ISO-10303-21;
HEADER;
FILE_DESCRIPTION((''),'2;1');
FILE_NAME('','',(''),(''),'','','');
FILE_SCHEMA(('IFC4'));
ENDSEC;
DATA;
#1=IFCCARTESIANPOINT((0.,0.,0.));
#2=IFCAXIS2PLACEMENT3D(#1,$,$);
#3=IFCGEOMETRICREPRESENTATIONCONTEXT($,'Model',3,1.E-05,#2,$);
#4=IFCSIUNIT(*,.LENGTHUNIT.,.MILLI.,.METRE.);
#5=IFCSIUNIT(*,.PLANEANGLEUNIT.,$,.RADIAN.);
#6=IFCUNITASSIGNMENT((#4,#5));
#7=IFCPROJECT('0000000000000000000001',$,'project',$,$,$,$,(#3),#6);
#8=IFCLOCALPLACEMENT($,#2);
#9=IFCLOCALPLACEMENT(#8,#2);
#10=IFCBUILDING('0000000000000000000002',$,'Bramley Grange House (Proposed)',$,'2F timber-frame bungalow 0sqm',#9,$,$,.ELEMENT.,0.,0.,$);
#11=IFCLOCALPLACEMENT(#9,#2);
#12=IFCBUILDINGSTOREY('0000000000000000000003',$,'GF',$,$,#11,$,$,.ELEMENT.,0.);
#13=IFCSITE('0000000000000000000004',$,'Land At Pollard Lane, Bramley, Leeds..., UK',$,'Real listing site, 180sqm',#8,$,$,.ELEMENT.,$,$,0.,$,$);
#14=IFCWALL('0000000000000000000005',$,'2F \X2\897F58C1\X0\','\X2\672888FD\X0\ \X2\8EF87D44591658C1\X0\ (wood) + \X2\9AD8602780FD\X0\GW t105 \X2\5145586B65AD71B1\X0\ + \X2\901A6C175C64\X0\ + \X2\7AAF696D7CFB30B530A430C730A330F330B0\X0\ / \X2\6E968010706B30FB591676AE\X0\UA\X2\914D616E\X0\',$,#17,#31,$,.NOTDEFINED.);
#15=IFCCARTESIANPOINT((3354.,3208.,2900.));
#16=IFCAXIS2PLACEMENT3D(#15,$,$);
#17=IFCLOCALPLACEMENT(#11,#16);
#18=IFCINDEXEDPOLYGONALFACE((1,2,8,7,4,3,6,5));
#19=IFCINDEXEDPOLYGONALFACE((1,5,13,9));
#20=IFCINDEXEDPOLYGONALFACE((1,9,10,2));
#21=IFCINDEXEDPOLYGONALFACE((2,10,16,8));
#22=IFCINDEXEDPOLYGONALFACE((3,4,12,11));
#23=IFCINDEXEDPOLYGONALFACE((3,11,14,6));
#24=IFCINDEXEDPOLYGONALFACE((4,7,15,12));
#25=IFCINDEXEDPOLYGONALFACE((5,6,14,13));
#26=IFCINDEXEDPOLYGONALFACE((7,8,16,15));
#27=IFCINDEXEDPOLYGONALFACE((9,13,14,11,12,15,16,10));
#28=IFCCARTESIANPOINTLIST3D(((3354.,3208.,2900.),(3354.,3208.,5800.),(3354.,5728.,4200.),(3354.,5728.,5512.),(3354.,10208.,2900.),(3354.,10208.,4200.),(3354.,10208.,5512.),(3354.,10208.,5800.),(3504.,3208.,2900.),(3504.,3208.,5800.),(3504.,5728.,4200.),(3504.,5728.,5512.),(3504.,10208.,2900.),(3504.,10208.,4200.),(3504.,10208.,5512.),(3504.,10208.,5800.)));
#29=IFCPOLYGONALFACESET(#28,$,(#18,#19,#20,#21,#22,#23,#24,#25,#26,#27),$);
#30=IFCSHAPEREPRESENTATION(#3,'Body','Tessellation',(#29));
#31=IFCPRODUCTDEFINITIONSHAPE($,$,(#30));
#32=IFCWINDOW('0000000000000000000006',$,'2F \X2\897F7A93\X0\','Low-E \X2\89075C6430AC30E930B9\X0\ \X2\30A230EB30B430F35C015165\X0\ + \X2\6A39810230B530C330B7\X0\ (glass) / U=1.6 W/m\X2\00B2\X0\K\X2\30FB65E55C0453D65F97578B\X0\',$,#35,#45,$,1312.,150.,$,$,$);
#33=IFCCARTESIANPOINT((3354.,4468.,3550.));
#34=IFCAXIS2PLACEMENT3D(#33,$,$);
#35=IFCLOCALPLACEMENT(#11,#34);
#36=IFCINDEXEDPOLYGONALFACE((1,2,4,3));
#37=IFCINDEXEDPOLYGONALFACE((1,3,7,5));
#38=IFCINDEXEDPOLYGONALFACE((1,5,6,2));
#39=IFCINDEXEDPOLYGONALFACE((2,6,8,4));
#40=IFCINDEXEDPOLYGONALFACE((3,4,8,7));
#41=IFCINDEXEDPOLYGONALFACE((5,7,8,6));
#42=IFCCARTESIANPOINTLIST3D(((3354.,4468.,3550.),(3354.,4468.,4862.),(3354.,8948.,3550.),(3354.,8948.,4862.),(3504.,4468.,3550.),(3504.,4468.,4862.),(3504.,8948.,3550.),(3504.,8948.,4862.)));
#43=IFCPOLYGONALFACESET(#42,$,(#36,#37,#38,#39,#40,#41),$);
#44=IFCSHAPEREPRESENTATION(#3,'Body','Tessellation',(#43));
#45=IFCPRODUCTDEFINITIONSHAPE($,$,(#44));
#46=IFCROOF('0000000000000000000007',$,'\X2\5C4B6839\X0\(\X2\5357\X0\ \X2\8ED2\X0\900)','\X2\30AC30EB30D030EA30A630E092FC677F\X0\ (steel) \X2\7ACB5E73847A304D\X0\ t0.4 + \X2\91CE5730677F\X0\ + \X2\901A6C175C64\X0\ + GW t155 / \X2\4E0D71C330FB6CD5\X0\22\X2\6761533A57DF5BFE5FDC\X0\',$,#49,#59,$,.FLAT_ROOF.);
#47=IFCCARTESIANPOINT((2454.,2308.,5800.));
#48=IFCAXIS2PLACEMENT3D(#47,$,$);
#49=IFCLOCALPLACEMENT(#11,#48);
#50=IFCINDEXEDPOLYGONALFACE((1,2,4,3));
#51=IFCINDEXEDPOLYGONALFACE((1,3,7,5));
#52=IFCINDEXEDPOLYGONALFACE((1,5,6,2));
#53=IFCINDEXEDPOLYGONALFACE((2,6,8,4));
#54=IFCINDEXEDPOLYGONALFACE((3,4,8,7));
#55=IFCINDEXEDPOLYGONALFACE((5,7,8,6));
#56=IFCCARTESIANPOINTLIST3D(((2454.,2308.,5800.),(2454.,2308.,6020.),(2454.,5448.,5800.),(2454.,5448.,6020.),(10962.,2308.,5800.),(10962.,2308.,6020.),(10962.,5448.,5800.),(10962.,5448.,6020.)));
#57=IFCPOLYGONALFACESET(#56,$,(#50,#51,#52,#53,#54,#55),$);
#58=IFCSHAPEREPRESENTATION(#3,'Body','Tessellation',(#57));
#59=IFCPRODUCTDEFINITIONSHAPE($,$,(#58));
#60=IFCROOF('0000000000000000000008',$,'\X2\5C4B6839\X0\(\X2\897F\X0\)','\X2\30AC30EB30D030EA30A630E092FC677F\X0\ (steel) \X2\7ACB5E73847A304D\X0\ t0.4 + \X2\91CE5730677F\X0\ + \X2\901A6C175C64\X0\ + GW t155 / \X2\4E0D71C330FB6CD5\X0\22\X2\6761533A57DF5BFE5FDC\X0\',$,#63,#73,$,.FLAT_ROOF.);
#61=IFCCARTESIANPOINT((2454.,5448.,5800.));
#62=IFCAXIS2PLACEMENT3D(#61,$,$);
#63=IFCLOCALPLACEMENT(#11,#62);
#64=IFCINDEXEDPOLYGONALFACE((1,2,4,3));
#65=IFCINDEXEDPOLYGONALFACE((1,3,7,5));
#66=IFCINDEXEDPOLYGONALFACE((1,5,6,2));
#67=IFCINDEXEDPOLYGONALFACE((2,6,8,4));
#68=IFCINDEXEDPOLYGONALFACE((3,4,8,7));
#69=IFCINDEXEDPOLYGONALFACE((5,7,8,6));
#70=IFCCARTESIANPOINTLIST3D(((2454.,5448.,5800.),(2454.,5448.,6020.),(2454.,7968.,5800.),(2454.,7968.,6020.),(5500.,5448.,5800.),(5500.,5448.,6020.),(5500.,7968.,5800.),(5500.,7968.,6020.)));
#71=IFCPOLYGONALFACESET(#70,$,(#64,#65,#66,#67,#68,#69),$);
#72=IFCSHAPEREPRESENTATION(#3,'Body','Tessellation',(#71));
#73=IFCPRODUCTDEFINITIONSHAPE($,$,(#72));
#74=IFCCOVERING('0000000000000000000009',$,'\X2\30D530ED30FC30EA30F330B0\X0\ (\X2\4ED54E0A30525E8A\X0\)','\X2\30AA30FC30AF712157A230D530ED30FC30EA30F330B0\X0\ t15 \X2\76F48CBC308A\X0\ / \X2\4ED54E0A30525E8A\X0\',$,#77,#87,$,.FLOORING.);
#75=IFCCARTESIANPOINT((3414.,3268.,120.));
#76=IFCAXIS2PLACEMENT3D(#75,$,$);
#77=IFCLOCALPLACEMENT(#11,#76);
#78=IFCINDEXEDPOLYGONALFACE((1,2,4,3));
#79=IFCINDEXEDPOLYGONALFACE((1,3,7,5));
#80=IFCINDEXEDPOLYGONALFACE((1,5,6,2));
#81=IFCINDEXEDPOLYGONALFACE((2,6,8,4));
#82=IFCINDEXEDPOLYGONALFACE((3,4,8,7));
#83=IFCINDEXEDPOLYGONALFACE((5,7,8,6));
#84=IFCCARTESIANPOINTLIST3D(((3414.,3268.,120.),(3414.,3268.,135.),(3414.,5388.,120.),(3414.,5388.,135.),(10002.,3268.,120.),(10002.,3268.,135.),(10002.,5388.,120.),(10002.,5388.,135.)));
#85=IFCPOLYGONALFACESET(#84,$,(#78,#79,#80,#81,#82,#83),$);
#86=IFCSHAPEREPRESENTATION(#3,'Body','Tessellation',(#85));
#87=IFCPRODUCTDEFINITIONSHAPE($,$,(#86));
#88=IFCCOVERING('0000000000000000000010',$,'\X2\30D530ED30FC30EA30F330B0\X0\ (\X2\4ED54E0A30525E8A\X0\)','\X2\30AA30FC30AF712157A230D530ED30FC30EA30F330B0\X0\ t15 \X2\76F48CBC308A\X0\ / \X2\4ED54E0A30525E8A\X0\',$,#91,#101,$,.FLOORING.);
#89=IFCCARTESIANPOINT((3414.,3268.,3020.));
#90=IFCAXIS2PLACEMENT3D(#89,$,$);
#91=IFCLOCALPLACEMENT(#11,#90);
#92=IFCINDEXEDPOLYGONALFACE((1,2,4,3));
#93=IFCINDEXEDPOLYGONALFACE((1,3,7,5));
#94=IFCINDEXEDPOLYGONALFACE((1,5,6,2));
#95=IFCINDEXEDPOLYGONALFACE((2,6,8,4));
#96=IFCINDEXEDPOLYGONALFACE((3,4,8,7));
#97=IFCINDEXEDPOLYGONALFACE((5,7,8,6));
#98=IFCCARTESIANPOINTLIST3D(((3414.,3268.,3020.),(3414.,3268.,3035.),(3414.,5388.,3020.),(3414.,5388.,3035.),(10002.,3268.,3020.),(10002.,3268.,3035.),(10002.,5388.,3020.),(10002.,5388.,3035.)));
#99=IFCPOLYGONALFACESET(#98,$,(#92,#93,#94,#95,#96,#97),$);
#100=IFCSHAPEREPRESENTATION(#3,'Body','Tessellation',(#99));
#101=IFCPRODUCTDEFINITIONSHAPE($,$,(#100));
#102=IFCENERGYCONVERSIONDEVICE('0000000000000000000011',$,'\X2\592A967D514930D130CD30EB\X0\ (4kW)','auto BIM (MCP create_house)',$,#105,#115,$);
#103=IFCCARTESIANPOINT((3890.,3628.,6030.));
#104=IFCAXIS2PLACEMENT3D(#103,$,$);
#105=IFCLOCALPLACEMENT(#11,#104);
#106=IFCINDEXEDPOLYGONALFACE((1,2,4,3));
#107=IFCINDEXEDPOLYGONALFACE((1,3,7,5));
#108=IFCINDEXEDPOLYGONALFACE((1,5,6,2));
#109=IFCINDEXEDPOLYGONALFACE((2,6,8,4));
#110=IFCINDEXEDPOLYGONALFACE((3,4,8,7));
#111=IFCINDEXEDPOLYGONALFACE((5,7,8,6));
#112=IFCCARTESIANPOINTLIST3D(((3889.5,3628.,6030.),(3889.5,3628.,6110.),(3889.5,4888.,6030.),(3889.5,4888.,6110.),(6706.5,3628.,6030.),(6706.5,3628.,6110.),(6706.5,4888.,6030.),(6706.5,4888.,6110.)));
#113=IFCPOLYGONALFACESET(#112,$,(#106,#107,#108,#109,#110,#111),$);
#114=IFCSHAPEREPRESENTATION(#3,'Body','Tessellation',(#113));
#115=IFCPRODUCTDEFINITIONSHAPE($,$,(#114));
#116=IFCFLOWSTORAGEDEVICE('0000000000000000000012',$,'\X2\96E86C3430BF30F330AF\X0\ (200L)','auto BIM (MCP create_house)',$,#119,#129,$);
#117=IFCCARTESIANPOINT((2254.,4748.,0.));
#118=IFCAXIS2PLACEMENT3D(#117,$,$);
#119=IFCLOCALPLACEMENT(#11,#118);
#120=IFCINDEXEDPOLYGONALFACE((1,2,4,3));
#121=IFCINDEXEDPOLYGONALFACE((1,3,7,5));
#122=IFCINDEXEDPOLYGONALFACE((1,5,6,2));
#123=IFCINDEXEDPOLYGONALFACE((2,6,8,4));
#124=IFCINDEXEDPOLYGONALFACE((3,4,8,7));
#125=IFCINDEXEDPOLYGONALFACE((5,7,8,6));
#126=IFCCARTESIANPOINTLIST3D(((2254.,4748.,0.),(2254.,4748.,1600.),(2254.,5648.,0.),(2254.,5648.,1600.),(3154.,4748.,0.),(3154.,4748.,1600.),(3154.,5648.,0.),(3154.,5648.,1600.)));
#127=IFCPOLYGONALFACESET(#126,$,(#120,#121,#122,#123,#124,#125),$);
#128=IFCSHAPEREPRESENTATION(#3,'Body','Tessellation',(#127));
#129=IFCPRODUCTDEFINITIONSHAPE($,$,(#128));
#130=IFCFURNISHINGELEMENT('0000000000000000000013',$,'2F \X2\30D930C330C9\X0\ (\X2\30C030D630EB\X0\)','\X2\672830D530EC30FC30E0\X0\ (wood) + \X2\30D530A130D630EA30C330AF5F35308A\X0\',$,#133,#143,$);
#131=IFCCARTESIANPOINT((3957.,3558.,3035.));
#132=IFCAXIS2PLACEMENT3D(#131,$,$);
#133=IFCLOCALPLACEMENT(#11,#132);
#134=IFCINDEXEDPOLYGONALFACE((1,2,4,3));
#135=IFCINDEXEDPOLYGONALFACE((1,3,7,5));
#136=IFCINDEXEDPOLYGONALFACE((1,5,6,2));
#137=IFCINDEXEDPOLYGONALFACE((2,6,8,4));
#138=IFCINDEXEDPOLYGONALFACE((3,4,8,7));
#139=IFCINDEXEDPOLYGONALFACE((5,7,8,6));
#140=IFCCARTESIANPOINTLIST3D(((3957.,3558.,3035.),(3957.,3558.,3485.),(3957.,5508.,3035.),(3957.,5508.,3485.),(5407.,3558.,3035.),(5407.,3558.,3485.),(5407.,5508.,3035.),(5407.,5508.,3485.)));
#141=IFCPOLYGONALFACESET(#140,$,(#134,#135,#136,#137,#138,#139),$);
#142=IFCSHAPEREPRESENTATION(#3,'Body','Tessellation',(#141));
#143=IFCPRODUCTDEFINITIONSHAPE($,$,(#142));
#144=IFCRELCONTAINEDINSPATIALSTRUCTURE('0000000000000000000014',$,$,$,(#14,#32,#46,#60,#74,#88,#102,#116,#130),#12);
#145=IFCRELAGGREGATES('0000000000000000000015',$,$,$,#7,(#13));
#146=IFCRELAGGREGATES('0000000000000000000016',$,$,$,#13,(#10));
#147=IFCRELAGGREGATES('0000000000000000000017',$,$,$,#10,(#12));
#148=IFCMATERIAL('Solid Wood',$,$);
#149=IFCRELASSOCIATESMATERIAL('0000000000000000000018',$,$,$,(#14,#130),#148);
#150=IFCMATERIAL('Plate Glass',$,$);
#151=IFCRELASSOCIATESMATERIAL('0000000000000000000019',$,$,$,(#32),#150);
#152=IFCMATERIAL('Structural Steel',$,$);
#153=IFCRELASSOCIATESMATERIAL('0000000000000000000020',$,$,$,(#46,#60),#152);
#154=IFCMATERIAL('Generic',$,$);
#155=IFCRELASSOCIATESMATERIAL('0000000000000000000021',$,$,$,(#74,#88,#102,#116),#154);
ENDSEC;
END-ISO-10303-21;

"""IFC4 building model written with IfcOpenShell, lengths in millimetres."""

from ifc_helpers import new_model, si_unit, frame, frame_2d, origin, place, context, project, spatial, rectangle, extrude, material, element, fill, save


model = new_model("IFC4")

# Units and contexts
model_context = context("Model", 3, precision=1e-05, world=origin())
ifc_project = project(units=[si_unit("LENGTHUNIT", "METRE", prefix="MILLI"), si_unit("PLANEANGLEUNIT", "RADIAN")], contexts=[model_context])

# Site, building, storey
site_placement = place(None, origin())
site = spatial("IfcSite", under=ifc_project, at=site_placement, Name="Land At Pollard Lane, Bramley, Leeds..., UK", ObjectType="Real listing site, 180sqm", CompositionType="ELEMENT", RefElevation=0.0)
building_placement = place(site_placement, origin())
building = spatial("IfcBuilding", under=site, at=building_placement, Name="Bramley Grange House (Proposed)", ObjectType="2F timber-frame bungalow 0sqm", CompositionType="ELEMENT", ElevationOfRefHeight=0.0, ElevationOfTerrain=0.0)
storey_placement = place(building_placement, origin())
storey = spatial("IfcBuildingStorey", under=building, at=storey_placement, Name="GF", CompositionType="ELEMENT", Elevation=0.0)

# Shared definitions
ifc_material_1 = material(Name="Solid Wood")

# Shared definitions
ifc_material_2 = material(Name="Plate Glass")

# Wall, opening, window
wall_1_placement = place(storey_placement, frame((3354.0, 3208.0, 2900.0)))
wall_1 = element("IfcWall", 1, at=wall_1_placement, inside=storey, material=ifc_material_1, Name="2F 西壁", Description="木製 軸組外壁 (wood) + 高性能GW t105 充填断熱 + 通気層 + 窯業系サイディング / 準耐火・外皮UA配慮", PredefinedType="NOTDEFINED", context=model_context, shape_type="SweptSolid", body=[
    extrude(rectangle(XDim=150.0, YDim=7000.0, at=frame_2d((75.0, 3500.0))), frame((3354.0, 3208.0, 2900.0)), (0.0, 0.0, 1.0), 2900.0),
])
opening_1_placement = place(storey_placement, frame((3354.0, 4468.0, 3550.0)))
opening_1 = element("IfcOpeningElement", 2, at=opening_1_placement, cuts=wall_1, PredefinedType="NOTDEFINED", context=model_context, shape_type="SweptSolid", body=[
    extrude(rectangle(XDim=150.0, YDim=4480.0, at=frame_2d((75.0, 2240.0))), frame((3354.0, 4468.0, 3550.0)), (0.0, 0.0, 1.0), 1312.0),
])
window_1_placement = place(storey_placement, frame((3354.0, 4468.0, 3550.0)))
window_1 = element("IfcWindow", 3, at=window_1_placement, inside=storey, material=ifc_material_2, Name="2F 西窓", Description="Low-E 複層ガラス アルゴン封入 + 樹脂サッシ (glass) / U=1.6 W/m²K・日射取得型", OverallHeight=1312.0, OverallWidth=150.0, context=model_context, shape_type="SweptSolid", body=[
    extrude(rectangle(XDim=150.0, YDim=4480.0, at=frame_2d((75.0, 2240.0))), frame((3354.0, 4468.0, 3550.0)), (0.0, 0.0, 1.0), 1312.0),
])
fill(opening_1, window_1)

# Roofs
ifc_material_3 = material(Name="Structural Steel")
roof_1_placement = place(storey_placement, frame((2454.0, 2308.0, 5800.0)))
element("IfcRoof", 4, at=roof_1_placement, inside=storey, material=ifc_material_3, Name="屋根(南 軒900)", Description="ガルバリウム鋼板 (steel) 立平葺き t0.4 + 野地板 + 通気層 + GW t155 / 不燃・法22条区域対応", PredefinedType="FLAT_ROOF", context=model_context, shape_type="SweptSolid", body=[
    extrude(rectangle(XDim=8508.0, YDim=3140.0, at=frame_2d((4254.0, 1570.0))), frame((2454.0, 2308.0, 5800.0)), (0.0, 0.0, 1.0), 220.0),
])
roof_2_placement = place(storey_placement, frame((2454.0, 5448.0, 5800.0)))
element("IfcRoof", 5, at=roof_2_placement, inside=storey, material=ifc_material_3, Name="屋根(西)", Description="ガルバリウム鋼板 (steel) 立平葺き t0.4 + 野地板 + 通気層 + GW t155 / 不燃・法22条区域対応", PredefinedType="FLAT_ROOF", context=model_context, shape_type="SweptSolid", body=[
    extrude(rectangle(XDim=3046.0, YDim=2520.0, at=frame_2d((1523.0, 1260.0))), frame((2454.0, 5448.0, 5800.0)), (0.0, 0.0, 1.0), 220.0),
])

# Coverings
ifc_material_4 = material(Name="Generic")
covering_1_placement = place(storey_placement, frame((3414.0, 3268.0, 120.0)))
element("IfcCovering", 6, at=covering_1_placement, inside=storey, material=ifc_material_4, Name="フローリング (仕上げ床)", Description="オーク無垢フローリング t15 直貼り / 仕上げ床", PredefinedType="FLOORING", context=model_context, shape_type="SweptSolid", body=[
    extrude(rectangle(XDim=6588.0, YDim=2120.0, at=frame_2d((3294.0, 1060.0))), frame((3414.0, 3268.0, 120.0)), (0.0, 0.0, 1.0), 15.0),
])
covering_2_placement = place(storey_placement, frame((3414.0, 3268.0, 3020.0)))
element("IfcCovering", 7, at=covering_2_placement, inside=storey, material=ifc_material_4, Name="フローリング (仕上げ床)", Description="オーク無垢フローリング t15 直貼り / 仕上げ床", PredefinedType="FLOORING", context=model_context, shape_type="SweptSolid", body=[
    extrude(rectangle(XDim=6588.0, YDim=2120.0, at=frame_2d((3294.0, 1060.0))), frame((3414.0, 3268.0, 3020.0)), (0.0, 0.0, 1.0), 15.0),
])

# Energy conversion device
energy_conversion_device_placement = place(storey_placement, frame((3890.0, 3628.0, 6030.0)))
element("IfcEnergyConversionDevice", 8, at=energy_conversion_device_placement, inside=storey, material=ifc_material_4, Name="太陽光パネル (4kW)", Description="auto BIM (MCP create_house)", context=model_context, shape_type="SweptSolid", body=[
    extrude(rectangle(XDim=2817.0, YDim=1260.0, at=frame_2d((1408.0, 630.0))), frame((3890.0, 3628.0, 6030.0)), (0.0, 0.0, 1.0), 80.0),
])

# Flow storage device
flow_storage_device_placement = place(storey_placement, frame((2254.0, 4748.0, 0.0)))
element("IfcFlowStorageDevice", 9, at=flow_storage_device_placement, inside=storey, material=ifc_material_4, Name="雨水タンク (200L)", Description="auto BIM (MCP create_house)", context=model_context, shape_type="SweptSolid", body=[
    extrude(rectangle(XDim=900.0, YDim=900.0, at=frame_2d((450.0, 450.0))), frame((2254.0, 4748.0, 0.0)), (0.0, 0.0, 1.0), 1600.0),
])

# Furnishing element
furnishing_placement = place(storey_placement, frame((3957.0, 3558.0, 3035.0)))
element("IfcFurnishingElement", 10, at=furnishing_placement, inside=storey, material=ifc_material_1, Name="2F ベッド (ダブル)", Description="木フレーム (wood) + ファブリック張り", context=model_context, shape_type="SweptSolid", body=[
    extrude(rectangle(XDim=1450.0, YDim=1950.0, at=frame_2d((725.0, 975.0))), frame((3957.0, 3558.0, 3035.0)), (0.0, 0.0, 1.0), 450.0),
])

save(model, "model.ifc")
